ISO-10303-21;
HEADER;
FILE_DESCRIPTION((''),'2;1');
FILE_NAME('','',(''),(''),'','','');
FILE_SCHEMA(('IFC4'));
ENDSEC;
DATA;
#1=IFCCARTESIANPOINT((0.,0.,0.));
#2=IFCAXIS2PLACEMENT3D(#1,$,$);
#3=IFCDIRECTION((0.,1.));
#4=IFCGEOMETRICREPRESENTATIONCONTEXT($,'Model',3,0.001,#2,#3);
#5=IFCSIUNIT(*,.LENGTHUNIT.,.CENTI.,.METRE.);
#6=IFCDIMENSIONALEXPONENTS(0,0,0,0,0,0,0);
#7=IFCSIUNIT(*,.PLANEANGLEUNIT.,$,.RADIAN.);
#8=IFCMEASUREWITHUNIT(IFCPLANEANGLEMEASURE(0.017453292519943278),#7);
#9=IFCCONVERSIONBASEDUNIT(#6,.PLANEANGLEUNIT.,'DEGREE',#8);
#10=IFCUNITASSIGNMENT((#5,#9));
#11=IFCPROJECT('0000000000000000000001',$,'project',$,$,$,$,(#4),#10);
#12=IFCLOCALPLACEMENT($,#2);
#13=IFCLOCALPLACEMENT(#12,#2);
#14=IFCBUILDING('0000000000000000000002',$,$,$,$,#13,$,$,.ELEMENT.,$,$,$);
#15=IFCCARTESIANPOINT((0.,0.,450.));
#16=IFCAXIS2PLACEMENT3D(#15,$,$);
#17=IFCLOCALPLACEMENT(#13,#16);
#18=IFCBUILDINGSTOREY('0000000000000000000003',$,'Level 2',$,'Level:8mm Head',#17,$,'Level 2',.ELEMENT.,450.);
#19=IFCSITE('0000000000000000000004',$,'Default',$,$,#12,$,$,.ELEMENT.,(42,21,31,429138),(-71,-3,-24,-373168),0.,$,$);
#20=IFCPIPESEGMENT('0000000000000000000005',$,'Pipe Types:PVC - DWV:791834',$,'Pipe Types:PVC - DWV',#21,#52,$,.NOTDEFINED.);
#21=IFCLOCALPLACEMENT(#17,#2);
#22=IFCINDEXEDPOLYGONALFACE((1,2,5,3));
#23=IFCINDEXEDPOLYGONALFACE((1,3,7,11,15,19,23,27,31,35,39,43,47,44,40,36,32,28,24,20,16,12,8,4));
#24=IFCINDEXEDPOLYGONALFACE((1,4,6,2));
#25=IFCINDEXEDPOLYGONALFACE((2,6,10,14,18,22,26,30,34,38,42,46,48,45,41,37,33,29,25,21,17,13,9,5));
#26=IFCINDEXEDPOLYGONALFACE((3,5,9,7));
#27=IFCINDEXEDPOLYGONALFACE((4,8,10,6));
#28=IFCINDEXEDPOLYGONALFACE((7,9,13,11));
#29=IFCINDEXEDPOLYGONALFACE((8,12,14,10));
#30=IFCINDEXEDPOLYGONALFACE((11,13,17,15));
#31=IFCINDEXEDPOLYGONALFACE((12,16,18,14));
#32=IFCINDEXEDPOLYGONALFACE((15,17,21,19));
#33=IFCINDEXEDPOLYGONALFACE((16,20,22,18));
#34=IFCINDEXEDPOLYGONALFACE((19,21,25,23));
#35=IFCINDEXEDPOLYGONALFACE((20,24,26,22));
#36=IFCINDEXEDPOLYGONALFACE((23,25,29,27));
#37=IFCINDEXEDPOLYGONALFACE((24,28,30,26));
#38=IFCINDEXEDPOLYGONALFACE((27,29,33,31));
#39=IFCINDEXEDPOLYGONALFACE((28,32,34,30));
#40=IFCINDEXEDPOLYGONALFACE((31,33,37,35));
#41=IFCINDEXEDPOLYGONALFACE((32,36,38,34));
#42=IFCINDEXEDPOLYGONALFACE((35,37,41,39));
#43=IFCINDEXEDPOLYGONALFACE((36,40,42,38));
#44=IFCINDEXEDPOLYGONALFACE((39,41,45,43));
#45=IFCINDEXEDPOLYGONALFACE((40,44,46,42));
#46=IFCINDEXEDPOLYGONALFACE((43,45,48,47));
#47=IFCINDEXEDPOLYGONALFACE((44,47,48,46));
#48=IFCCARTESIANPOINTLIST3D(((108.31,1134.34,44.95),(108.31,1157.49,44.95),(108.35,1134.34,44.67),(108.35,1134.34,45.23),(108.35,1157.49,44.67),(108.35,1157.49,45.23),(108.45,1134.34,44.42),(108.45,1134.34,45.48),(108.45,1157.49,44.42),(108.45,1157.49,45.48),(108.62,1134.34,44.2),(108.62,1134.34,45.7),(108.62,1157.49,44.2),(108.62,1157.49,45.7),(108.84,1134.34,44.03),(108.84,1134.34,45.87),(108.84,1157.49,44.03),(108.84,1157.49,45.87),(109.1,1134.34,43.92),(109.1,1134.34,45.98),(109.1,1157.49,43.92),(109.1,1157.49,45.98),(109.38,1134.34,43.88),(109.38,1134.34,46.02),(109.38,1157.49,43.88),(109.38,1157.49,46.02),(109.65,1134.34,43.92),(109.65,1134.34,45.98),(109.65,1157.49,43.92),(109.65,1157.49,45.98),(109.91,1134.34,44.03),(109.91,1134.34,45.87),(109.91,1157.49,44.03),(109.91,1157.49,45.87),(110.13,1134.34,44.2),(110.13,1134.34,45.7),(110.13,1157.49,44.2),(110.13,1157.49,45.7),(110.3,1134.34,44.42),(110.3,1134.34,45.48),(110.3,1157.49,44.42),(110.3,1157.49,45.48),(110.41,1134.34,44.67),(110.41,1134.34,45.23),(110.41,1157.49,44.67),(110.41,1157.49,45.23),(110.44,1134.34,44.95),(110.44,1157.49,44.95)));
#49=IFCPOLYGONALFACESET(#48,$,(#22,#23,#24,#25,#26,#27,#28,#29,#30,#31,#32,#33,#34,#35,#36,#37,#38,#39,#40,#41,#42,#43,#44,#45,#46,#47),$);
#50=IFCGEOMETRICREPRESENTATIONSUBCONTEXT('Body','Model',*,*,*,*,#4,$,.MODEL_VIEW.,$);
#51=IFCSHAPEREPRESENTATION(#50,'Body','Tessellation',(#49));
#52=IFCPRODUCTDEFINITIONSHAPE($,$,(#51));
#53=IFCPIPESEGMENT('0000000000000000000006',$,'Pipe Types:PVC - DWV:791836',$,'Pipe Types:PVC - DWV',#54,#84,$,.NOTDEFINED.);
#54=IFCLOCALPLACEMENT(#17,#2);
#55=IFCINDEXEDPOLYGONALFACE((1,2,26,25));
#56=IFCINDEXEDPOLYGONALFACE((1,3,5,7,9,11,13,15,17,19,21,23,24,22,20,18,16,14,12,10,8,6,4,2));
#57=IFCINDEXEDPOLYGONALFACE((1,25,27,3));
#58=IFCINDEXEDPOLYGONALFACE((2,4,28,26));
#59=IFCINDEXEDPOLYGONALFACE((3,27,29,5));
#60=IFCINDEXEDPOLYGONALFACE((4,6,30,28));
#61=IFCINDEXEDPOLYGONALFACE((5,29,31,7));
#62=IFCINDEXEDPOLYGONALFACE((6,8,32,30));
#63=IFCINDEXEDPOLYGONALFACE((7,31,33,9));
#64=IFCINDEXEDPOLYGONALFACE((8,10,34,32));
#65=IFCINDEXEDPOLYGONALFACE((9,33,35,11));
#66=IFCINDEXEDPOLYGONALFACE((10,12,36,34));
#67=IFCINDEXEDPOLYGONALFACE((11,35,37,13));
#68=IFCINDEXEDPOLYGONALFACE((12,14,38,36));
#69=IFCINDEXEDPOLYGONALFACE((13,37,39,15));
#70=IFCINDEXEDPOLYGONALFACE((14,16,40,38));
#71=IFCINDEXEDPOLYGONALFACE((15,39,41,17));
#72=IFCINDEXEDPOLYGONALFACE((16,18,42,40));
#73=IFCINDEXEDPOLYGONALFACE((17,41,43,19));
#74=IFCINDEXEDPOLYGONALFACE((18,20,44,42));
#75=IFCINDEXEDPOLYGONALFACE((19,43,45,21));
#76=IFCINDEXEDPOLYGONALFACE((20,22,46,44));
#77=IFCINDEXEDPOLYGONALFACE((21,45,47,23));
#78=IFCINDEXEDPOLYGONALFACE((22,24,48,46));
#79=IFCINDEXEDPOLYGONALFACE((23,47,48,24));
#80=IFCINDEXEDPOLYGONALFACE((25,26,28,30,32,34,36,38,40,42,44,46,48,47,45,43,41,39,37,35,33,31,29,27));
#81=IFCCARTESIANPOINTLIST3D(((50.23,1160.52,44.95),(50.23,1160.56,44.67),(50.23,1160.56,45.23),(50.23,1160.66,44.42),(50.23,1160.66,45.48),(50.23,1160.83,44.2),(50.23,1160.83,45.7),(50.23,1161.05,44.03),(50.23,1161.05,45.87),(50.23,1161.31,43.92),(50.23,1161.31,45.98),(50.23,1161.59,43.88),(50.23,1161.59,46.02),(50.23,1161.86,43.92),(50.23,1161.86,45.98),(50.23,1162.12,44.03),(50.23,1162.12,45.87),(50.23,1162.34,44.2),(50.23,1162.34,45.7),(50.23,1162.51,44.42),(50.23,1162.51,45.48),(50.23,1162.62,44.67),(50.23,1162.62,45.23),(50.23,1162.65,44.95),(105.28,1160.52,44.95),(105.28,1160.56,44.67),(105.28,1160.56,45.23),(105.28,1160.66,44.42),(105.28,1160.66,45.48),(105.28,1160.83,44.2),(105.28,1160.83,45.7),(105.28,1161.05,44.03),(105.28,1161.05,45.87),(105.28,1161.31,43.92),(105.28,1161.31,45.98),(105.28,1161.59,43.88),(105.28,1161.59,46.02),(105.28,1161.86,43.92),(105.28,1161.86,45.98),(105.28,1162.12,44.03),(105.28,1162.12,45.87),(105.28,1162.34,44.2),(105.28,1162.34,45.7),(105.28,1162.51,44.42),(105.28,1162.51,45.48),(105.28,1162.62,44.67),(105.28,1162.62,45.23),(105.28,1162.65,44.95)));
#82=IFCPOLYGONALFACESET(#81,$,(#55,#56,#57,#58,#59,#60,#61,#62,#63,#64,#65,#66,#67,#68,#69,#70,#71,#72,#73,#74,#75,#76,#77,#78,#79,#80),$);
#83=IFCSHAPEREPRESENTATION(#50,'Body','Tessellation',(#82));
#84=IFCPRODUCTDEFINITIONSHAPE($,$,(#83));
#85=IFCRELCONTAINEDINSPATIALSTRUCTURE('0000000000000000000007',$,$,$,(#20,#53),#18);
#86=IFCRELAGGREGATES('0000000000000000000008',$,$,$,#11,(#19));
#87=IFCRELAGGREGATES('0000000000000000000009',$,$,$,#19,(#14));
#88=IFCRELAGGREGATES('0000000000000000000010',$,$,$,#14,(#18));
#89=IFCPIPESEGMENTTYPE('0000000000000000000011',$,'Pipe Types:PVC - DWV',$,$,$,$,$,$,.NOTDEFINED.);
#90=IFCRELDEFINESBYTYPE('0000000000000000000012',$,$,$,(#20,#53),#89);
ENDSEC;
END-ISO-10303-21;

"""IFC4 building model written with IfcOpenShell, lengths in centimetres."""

from ifc_helpers import new_model, entity, si_unit, converted_unit, direction, frame, origin, place, context, subcontext, project, spatial, arc, indexed_curve, outline, extrude, type_object, element, save


model = new_model("IFC4")

# Units and contexts
model_context = context("Model", 3, precision=0.001, world=origin(), true_north=direction((0.0, 1.0)))
body_context = subcontext(model_context, "Body", "Model", "MODEL_VIEW")
ifc_project = project(units=[si_unit("LENGTHUNIT", "METRE", prefix="CENTI"), converted_unit("PLANEANGLEUNIT", "DEGREE", entity("IfcPlaneAngleMeasure", 0.017453292519943278), si_unit("PLANEANGLEUNIT", "RADIAN"), dimensions=[0, 0, 0, 0, 0, 0, 0])], contexts=[model_context])

# Site, building, storey
site_placement = place(None, origin())
site = spatial("IfcSite", under=ifc_project, at=site_placement, Name="Default", CompositionType="ELEMENT", RefLatitude=(42, 21, 31, 429138), RefLongitude=(-71, -3, -24, -373168), RefElevation=0.0)
building_placement = place(site_placement, origin())
building = spatial("IfcBuilding", under=site, at=building_placement, CompositionType="ELEMENT")
storey_placement = place(building_placement, frame((0.0, 0.0, 450.0)))
storey = spatial("IfcBuildingStorey", under=building, at=storey_placement, Name="Level 2", ObjectType="Level:8mm Head", LongName="Level 2", CompositionType="ELEMENT", Elevation=450.0)

# Pipe segments
pipe_segment_type = type_object("IfcPipeSegmentType", Name="Pipe Types:PVC - DWV", PredefinedType="NOTDEFINED")
pipe_segment_1_placement = place(storey_placement, origin())
element("IfcPipeSegment", 1, at=pipe_segment_1_placement, inside=storey, type_object=pipe_segment_type, Name="Pipe Types:PVC - DWV:791834", ObjectType="Pipe Types:PVC - DWV", PredefinedType="NOTDEFINED", context=body_context, shape_type="SweptSolid", body=[
    extrude(outline(indexed_curve([(1.07, 0.0), (0.75, 0.75), (0.0, 1.07), (-0.75, 0.75), (-1.07, 0.0), (-0.75, -0.75), (0.0, -1.07), (0.75, -0.75)], segments=[arc(1, 2, 3), arc(3, 4, 5), arc(5, 6, 7), arc(7, 8, 1)], self_intersect=False)), frame((109.38, 1134.34, 44.95), z_axis=(0.0, 1.0, 0.0), x_axis=(1.0, 0.0, 0.0)), (0.0, 0.0, 1.0), 23.14),
])
pipe_segment_2_placement = place(storey_placement, origin())
element("IfcPipeSegment", 2, at=pipe_segment_2_placement, inside=storey, type_object=pipe_segment_type, Name="Pipe Types:PVC - DWV:791836", ObjectType="Pipe Types:PVC - DWV", PredefinedType="NOTDEFINED", context=body_context, shape_type="SweptSolid", body=[
    extrude(outline(indexed_curve([(1.07, 0.0), (0.75, 0.75), (0.0, 1.07), (-0.75, 0.75), (-1.07, 0.0), (-0.75, -0.75), (0.0, -1.07), (0.75, -0.75)], segments=[arc(1, 2, 3), arc(3, 4, 5), arc(5, 6, 7), arc(7, 8, 1)], self_intersect=False)), frame((50.23, 1161.59, 44.95), z_axis=(1.0, 0.0, 0.0), x_axis=(0.0, 1.0, 0.0)), (0.0, 0.0, 1.0), 55.04),
])

save(model, "model.ifc")
